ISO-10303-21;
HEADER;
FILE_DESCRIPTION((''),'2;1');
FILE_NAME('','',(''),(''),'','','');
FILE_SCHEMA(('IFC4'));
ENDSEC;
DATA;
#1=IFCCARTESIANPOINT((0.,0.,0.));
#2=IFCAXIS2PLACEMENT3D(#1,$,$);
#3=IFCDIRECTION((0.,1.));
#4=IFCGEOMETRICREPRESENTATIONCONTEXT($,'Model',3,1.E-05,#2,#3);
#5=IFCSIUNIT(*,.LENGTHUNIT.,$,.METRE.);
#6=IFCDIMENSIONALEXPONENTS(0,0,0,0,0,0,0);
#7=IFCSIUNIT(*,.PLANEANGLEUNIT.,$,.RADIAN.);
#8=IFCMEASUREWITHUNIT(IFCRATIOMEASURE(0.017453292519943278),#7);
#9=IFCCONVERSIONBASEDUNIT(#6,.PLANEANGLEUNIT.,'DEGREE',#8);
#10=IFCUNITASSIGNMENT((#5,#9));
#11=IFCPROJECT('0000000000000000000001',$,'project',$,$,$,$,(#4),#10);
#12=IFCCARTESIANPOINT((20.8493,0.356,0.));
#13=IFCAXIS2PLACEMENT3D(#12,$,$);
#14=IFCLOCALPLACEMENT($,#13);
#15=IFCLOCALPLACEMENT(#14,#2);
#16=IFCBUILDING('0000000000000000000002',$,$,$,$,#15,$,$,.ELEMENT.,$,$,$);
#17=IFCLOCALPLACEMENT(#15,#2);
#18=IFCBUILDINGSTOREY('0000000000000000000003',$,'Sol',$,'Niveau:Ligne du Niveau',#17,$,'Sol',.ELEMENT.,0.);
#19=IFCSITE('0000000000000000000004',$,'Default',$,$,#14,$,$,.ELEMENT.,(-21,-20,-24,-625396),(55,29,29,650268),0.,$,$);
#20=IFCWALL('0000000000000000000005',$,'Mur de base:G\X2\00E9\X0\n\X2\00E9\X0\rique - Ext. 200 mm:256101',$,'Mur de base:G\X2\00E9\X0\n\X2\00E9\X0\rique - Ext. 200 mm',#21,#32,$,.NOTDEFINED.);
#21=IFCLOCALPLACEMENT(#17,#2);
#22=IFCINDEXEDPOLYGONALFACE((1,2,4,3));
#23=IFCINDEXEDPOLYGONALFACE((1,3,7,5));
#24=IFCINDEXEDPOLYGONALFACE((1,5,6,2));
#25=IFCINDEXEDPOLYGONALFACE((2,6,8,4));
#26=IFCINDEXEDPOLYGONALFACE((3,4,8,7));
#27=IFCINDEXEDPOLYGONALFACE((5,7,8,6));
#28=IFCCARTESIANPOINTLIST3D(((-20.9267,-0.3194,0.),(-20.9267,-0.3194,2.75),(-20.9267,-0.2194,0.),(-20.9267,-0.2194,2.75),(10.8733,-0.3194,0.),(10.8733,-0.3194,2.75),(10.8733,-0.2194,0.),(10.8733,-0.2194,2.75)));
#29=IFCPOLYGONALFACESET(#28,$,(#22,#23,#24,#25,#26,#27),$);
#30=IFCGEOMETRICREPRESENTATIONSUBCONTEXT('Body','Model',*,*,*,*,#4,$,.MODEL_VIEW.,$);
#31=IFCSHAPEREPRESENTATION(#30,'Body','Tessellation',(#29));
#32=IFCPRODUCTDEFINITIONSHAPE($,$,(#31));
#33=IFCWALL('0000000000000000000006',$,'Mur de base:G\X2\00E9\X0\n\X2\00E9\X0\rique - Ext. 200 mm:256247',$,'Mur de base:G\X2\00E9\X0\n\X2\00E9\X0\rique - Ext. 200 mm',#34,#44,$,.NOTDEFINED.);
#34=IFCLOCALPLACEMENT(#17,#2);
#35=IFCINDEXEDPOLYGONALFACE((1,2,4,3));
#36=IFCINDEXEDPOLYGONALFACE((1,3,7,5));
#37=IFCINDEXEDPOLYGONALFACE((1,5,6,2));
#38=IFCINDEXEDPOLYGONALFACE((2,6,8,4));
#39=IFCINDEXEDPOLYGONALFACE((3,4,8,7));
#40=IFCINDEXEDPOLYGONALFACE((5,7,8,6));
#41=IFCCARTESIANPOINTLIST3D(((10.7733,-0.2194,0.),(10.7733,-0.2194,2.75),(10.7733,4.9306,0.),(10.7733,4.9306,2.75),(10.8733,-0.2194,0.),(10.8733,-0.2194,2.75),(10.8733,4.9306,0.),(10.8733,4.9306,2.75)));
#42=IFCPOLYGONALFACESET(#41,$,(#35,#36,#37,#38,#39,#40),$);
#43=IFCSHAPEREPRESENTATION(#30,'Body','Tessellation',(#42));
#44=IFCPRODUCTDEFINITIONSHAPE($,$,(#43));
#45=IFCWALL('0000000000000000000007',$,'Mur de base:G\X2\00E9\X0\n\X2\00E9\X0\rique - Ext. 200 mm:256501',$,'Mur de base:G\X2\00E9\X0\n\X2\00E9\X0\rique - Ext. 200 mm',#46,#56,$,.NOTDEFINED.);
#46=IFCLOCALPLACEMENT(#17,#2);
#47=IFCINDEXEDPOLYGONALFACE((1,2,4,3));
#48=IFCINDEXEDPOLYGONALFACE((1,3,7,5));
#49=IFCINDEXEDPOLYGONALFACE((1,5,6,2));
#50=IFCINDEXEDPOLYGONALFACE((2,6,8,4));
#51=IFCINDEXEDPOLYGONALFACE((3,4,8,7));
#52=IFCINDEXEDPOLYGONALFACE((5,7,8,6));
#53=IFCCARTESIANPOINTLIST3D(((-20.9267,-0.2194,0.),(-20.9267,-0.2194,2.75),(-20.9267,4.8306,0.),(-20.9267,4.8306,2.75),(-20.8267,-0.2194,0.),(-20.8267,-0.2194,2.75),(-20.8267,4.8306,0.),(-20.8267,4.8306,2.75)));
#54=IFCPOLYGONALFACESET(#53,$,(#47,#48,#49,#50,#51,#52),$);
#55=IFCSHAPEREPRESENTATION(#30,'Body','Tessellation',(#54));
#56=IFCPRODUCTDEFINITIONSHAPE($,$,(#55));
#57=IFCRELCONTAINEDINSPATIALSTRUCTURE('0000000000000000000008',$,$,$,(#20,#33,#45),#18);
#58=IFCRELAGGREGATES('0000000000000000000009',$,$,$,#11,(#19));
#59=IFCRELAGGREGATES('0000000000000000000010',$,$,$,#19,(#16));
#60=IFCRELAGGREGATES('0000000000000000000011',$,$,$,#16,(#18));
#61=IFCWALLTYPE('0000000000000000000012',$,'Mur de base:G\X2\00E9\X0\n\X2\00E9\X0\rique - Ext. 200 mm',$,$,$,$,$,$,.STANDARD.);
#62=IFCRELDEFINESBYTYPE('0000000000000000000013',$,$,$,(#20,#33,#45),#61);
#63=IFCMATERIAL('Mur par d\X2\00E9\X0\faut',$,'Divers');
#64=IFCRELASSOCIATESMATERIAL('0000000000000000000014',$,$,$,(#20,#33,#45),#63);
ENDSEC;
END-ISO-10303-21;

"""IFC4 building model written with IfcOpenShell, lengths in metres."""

from ifc_helpers import new_model, entity, si_unit, converted_unit, direction, frame, origin, place, context, subcontext, project, spatial, indexed_curve, outline, extrude, material, type_object, element, save


model = new_model("IFC4")

# Units and contexts
model_context = context("Model", 3, precision=1e-05, world=origin(), true_north=direction((0.0, 1.0)))
body_context = subcontext(model_context, "Body", "Model", "MODEL_VIEW")
ifc_project = project(units=[si_unit("LENGTHUNIT", "METRE"), converted_unit("PLANEANGLEUNIT", "DEGREE", entity("IfcRatioMeasure", 0.017453292519943278), si_unit("PLANEANGLEUNIT", "RADIAN"), dimensions=[0, 0, 0, 0, 0, 0, 0])], contexts=[model_context])

# Site, building, storey
site_placement = place(None, frame((20.8493, 0.356, 0.0)))
site = spatial("IfcSite", under=ifc_project, at=site_placement, Name="Default", CompositionType="ELEMENT", RefLatitude=(-21, -20, -24, -625396), RefLongitude=(55, 29, 29, 650268), RefElevation=0.0)
building_placement = place(site_placement, origin())
building = spatial("IfcBuilding", under=site, at=building_placement, CompositionType="ELEMENT")
storey_placement = place(building_placement, origin())
storey = spatial("IfcBuildingStorey", under=building, at=storey_placement, Name="Sol", ObjectType="Niveau:Ligne du Niveau", LongName="Sol", CompositionType="ELEMENT", Elevation=0.0)

# Walls
ifc_material = material(Name="Mur par défaut", Category="Divers")
wall_type = type_object("IfcWallType", Name="Mur de base:Générique - Ext. 200 mm", PredefinedType="STANDARD")
wall_1_placement = place(storey_placement, frame((-20.9267, -0.2694, 0.0)))
element("IfcWall", 1, at=wall_1_placement, inside=storey, type_object=wall_type, material=ifc_material, Name="Mur de base:Générique - Ext. 200 mm:256101", ObjectType="Mur de base:Générique - Ext. 200 mm", PredefinedType="NOTDEFINED", context=body_context, shape_type="SweptSolid", body=[
    extrude(outline(indexed_curve([(31.8, 0.05), (0.0, 0.05), (0.0, -0.05), (31.8, -0.05), (31.8, 0.05)], self_intersect=False)), origin(), (0.0, 0.0, 1.0), 2.75),
])
wall_2_placement = place(storey_placement, frame((10.8233, -0.2194, 0.0), z_axis=(0.0, 0.0, 1.0), x_axis=(0.0, 1.0, 0.0)))
element("IfcWall", 2, at=wall_2_placement, inside=storey, type_object=wall_type, material=ifc_material, Name="Mur de base:Générique - Ext. 200 mm:256247", ObjectType="Mur de base:Générique - Ext. 200 mm", PredefinedType="NOTDEFINED", context=body_context, shape_type="SweptSolid", body=[
    extrude(outline(indexed_curve([(5.15, 0.05), (0.0, 0.05), (0.0, -0.05), (5.15, -0.05), (5.15, 0.05)], self_intersect=False)), origin(), (0.0, 0.0, 1.0), 2.75),
])
wall_3_placement = place(storey_placement, frame((-20.8767, 4.8306, 0.0), z_axis=(0.0, 0.0, 1.0), x_axis=(0.0, -1.0, 0.0)))
element("IfcWall", 3, at=wall_3_placement, inside=storey, type_object=wall_type, material=ifc_material, Name="Mur de base:Générique - Ext. 200 mm:256501", ObjectType="Mur de base:Générique - Ext. 200 mm", PredefinedType="NOTDEFINED", context=body_context, shape_type="SweptSolid", body=[
    extrude(outline(indexed_curve([(5.05, 0.05), (0.0, 0.05), (0.0, -0.05), (5.05, -0.05), (5.05, 0.05)], self_intersect=False)), origin(), (0.0, 0.0, 1.0), 2.75),
])

save(model, "model.ifc")
